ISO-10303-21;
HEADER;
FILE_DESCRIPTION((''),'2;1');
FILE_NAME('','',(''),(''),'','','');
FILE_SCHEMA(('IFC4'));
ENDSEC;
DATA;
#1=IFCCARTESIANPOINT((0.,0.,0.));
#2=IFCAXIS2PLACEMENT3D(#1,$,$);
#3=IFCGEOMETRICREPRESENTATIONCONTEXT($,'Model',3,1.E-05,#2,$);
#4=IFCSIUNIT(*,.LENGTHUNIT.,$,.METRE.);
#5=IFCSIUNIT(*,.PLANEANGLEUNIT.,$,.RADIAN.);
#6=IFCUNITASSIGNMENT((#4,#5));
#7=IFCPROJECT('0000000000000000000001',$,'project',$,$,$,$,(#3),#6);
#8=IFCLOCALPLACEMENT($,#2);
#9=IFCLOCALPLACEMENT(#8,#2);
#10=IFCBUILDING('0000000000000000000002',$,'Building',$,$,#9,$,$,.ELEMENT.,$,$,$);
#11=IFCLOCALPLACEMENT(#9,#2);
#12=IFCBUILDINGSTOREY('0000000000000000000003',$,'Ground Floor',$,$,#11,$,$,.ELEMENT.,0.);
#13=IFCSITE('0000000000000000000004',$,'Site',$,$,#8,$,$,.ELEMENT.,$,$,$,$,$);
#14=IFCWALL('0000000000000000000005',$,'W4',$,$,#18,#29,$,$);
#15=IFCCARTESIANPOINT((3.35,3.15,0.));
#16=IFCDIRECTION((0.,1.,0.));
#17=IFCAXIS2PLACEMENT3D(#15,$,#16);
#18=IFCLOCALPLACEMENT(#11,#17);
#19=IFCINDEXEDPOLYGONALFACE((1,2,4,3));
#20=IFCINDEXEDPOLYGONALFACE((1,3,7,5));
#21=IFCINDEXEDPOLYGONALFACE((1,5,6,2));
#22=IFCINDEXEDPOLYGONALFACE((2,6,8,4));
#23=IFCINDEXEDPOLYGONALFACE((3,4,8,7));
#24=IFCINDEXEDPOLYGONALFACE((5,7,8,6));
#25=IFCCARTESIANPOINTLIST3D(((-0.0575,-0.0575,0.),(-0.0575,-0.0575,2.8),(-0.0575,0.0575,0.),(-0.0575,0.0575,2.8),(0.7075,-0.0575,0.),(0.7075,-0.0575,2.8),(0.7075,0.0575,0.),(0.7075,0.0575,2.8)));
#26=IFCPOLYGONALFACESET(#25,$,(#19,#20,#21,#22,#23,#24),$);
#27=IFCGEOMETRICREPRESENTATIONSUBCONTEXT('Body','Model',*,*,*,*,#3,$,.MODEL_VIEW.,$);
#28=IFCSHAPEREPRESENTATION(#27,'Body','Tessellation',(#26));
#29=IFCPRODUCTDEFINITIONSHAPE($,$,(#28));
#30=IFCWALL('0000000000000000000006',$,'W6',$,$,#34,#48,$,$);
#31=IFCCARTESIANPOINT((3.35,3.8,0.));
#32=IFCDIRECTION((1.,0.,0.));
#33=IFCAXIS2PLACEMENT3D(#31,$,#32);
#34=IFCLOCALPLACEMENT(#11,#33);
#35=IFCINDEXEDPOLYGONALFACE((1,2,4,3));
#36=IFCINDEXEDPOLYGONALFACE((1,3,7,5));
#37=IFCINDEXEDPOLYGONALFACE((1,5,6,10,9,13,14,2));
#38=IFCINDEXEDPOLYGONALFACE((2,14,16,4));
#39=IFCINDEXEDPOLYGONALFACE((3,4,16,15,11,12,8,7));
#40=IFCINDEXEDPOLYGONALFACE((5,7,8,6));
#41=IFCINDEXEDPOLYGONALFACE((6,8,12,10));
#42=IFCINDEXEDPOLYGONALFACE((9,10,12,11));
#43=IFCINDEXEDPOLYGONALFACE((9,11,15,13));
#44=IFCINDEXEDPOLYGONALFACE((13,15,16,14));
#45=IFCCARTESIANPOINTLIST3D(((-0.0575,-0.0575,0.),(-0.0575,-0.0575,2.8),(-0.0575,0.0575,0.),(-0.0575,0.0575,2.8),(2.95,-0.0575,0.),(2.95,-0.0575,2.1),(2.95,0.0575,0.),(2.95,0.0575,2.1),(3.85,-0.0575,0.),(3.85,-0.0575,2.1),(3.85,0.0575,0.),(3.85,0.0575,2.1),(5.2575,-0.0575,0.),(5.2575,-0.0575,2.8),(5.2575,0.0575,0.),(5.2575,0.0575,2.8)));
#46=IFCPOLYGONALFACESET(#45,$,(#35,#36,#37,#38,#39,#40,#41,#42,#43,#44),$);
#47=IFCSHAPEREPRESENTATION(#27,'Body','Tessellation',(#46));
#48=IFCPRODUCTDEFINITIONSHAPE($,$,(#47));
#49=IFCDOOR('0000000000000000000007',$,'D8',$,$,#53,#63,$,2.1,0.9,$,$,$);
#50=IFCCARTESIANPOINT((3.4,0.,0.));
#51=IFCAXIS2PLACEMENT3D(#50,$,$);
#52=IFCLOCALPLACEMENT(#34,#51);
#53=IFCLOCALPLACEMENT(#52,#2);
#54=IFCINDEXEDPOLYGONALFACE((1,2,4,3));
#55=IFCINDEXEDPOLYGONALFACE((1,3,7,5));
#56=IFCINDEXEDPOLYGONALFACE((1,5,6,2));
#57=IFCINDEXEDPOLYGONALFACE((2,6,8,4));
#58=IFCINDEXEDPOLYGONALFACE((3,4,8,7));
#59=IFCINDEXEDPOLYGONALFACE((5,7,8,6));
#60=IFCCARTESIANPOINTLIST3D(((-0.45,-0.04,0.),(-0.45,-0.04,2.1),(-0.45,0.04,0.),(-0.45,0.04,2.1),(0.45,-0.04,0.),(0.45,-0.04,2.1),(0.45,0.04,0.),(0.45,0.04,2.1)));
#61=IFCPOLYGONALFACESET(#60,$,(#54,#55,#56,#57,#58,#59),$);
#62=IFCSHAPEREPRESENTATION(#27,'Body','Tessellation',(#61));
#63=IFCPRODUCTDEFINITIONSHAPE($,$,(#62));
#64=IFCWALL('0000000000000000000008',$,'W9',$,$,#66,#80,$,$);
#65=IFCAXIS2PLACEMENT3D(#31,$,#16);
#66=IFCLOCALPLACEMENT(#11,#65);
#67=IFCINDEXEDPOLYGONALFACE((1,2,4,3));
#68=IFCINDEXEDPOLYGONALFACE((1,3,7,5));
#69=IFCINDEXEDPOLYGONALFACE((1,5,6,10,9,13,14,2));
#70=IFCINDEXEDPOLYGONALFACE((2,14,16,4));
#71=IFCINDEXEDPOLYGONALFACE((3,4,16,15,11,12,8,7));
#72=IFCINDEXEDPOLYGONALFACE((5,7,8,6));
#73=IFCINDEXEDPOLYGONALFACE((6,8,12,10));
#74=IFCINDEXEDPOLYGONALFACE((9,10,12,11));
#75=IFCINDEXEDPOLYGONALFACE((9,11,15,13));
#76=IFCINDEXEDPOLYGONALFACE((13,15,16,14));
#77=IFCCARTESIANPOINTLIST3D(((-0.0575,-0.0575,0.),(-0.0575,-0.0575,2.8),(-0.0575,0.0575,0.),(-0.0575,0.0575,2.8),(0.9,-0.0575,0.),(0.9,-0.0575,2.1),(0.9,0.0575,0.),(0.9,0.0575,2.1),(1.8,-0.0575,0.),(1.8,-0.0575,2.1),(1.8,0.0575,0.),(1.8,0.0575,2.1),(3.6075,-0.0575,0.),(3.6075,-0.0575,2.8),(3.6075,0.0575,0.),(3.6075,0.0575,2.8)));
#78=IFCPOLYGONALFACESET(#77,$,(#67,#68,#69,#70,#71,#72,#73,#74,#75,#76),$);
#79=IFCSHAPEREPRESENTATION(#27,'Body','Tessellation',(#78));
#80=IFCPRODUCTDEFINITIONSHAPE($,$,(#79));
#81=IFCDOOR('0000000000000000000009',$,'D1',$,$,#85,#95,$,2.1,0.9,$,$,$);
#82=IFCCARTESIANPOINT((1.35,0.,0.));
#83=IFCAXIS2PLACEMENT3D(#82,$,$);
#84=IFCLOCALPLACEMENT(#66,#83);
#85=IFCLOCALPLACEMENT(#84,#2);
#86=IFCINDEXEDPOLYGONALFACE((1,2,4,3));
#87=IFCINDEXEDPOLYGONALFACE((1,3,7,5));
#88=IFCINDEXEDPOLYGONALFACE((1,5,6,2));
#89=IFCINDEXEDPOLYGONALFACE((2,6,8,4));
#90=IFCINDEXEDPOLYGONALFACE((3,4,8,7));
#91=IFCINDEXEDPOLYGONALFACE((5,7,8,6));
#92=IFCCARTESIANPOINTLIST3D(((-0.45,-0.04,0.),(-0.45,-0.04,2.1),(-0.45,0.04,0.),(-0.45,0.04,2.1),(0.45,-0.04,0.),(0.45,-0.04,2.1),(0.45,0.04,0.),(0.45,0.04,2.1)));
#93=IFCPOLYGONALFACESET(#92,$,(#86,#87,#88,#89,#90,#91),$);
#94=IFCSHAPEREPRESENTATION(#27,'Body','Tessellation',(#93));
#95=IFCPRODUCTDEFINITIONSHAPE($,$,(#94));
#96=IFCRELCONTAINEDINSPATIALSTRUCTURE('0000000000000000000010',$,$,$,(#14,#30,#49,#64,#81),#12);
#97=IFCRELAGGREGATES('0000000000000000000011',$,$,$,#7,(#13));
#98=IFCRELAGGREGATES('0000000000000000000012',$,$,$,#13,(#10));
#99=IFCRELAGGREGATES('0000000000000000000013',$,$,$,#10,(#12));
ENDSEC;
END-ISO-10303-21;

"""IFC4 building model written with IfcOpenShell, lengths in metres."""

from ifc_helpers import new_model, si_unit, frame, frame_2d, origin, origin_2d, place, context, subcontext, project, spatial, rectangle, extrude, element, fill, save


model = new_model("IFC4")

# Units and contexts
model_context = context("Model", 3, precision=1e-05, world=origin())
body_context = subcontext(model_context, "Body", "Model", "MODEL_VIEW")
ifc_project = project(units=[si_unit("LENGTHUNIT", "METRE"), si_unit("PLANEANGLEUNIT", "RADIAN")], contexts=[model_context])

# Site, building, storey
site_placement = place(None, origin())
site = spatial("IfcSite", under=ifc_project, at=site_placement, Name="Site", CompositionType="ELEMENT")
building_placement = place(site_placement, origin())
building = spatial("IfcBuilding", under=site, at=building_placement, Name="Building", CompositionType="ELEMENT")
storey_placement = place(building_placement, origin())
storey = spatial("IfcBuildingStorey", under=building, at=storey_placement, Name="Ground Floor", CompositionType="ELEMENT", Elevation=0.0)

# Wall
wall_1_placement = place(storey_placement, frame((3.35, 3.15, 0.0), x_axis=(0.0, 1.0, 0.0)))
element("IfcWall", 1, at=wall_1_placement, inside=storey, Name="W4", context=body_context, shape_type="SweptSolid", body=[
    extrude(rectangle(XDim=0.765, YDim=0.115, at=frame_2d((0.325, 0.0))), origin(), (0.0, 0.0, 1.0), 2.8),
])

# Walls, openings, doors
wall_2_placement = place(storey_placement, frame((3.35, 3.8, 0.0), x_axis=(1.0, 0.0, 0.0)))
wall_2 = element("IfcWall", 2, at=wall_2_placement, inside=storey, Name="W6", context=body_context, shape_type="SweptSolid", body=[
    extrude(rectangle(XDim=5.315, YDim=0.115, at=frame_2d((2.6, 0.0))), origin(), (0.0, 0.0, 1.0), 2.8),
])
opening_1_placement = place(wall_2_placement, frame((3.4, 0.0, 0.0)))
opening_1 = element("IfcOpeningElement", 3, at=opening_1_placement, cuts=wall_2, context=body_context, shape_type="SweptSolid", body=[
    extrude(rectangle(XDim=0.9, YDim=0.215, at=origin_2d()), origin(), (0.0, 0.0, 1.0), 2.1),
])
door_1_placement = place(opening_1_placement, origin())
door_1 = element("IfcDoor", 4, at=door_1_placement, inside=storey, Name="D8", OverallHeight=2.1, OverallWidth=0.9, context=body_context, shape_type="SweptSolid", body=[
    extrude(rectangle(XDim=0.9, YDim=0.08, at=origin_2d()), origin(), (0.0, 0.0, 1.0), 2.1),
])
fill(opening_1, door_1)
wall_3_placement = place(storey_placement, frame((3.35, 3.8, 0.0), x_axis=(0.0, 1.0, 0.0)))
wall_3 = element("IfcWall", 5, at=wall_3_placement, inside=storey, Name="W9", context=body_context, shape_type="SweptSolid", body=[
    extrude(rectangle(XDim=3.665, YDim=0.115, at=frame_2d((1.775, 0.0))), origin(), (0.0, 0.0, 1.0), 2.8),
])
opening_2_placement = place(wall_3_placement, frame((1.35, 0.0, 0.0)))
opening_2 = element("IfcOpeningElement", 6, at=opening_2_placement, cuts=wall_3, context=body_context, shape_type="SweptSolid", body=[
    extrude(rectangle(XDim=0.9, YDim=0.215, at=origin_2d()), origin(), (0.0, 0.0, 1.0), 2.1),
])
door_2_placement = place(opening_2_placement, origin())
door_2 = element("IfcDoor", 7, at=door_2_placement, inside=storey, Name="D1", OverallHeight=2.1, OverallWidth=0.9, context=body_context, shape_type="SweptSolid", body=[
    extrude(rectangle(XDim=0.9, YDim=0.08, at=origin_2d()), origin(), (0.0, 0.0, 1.0), 2.1),
])
fill(opening_2, door_2)

save(model, "model.ifc")
